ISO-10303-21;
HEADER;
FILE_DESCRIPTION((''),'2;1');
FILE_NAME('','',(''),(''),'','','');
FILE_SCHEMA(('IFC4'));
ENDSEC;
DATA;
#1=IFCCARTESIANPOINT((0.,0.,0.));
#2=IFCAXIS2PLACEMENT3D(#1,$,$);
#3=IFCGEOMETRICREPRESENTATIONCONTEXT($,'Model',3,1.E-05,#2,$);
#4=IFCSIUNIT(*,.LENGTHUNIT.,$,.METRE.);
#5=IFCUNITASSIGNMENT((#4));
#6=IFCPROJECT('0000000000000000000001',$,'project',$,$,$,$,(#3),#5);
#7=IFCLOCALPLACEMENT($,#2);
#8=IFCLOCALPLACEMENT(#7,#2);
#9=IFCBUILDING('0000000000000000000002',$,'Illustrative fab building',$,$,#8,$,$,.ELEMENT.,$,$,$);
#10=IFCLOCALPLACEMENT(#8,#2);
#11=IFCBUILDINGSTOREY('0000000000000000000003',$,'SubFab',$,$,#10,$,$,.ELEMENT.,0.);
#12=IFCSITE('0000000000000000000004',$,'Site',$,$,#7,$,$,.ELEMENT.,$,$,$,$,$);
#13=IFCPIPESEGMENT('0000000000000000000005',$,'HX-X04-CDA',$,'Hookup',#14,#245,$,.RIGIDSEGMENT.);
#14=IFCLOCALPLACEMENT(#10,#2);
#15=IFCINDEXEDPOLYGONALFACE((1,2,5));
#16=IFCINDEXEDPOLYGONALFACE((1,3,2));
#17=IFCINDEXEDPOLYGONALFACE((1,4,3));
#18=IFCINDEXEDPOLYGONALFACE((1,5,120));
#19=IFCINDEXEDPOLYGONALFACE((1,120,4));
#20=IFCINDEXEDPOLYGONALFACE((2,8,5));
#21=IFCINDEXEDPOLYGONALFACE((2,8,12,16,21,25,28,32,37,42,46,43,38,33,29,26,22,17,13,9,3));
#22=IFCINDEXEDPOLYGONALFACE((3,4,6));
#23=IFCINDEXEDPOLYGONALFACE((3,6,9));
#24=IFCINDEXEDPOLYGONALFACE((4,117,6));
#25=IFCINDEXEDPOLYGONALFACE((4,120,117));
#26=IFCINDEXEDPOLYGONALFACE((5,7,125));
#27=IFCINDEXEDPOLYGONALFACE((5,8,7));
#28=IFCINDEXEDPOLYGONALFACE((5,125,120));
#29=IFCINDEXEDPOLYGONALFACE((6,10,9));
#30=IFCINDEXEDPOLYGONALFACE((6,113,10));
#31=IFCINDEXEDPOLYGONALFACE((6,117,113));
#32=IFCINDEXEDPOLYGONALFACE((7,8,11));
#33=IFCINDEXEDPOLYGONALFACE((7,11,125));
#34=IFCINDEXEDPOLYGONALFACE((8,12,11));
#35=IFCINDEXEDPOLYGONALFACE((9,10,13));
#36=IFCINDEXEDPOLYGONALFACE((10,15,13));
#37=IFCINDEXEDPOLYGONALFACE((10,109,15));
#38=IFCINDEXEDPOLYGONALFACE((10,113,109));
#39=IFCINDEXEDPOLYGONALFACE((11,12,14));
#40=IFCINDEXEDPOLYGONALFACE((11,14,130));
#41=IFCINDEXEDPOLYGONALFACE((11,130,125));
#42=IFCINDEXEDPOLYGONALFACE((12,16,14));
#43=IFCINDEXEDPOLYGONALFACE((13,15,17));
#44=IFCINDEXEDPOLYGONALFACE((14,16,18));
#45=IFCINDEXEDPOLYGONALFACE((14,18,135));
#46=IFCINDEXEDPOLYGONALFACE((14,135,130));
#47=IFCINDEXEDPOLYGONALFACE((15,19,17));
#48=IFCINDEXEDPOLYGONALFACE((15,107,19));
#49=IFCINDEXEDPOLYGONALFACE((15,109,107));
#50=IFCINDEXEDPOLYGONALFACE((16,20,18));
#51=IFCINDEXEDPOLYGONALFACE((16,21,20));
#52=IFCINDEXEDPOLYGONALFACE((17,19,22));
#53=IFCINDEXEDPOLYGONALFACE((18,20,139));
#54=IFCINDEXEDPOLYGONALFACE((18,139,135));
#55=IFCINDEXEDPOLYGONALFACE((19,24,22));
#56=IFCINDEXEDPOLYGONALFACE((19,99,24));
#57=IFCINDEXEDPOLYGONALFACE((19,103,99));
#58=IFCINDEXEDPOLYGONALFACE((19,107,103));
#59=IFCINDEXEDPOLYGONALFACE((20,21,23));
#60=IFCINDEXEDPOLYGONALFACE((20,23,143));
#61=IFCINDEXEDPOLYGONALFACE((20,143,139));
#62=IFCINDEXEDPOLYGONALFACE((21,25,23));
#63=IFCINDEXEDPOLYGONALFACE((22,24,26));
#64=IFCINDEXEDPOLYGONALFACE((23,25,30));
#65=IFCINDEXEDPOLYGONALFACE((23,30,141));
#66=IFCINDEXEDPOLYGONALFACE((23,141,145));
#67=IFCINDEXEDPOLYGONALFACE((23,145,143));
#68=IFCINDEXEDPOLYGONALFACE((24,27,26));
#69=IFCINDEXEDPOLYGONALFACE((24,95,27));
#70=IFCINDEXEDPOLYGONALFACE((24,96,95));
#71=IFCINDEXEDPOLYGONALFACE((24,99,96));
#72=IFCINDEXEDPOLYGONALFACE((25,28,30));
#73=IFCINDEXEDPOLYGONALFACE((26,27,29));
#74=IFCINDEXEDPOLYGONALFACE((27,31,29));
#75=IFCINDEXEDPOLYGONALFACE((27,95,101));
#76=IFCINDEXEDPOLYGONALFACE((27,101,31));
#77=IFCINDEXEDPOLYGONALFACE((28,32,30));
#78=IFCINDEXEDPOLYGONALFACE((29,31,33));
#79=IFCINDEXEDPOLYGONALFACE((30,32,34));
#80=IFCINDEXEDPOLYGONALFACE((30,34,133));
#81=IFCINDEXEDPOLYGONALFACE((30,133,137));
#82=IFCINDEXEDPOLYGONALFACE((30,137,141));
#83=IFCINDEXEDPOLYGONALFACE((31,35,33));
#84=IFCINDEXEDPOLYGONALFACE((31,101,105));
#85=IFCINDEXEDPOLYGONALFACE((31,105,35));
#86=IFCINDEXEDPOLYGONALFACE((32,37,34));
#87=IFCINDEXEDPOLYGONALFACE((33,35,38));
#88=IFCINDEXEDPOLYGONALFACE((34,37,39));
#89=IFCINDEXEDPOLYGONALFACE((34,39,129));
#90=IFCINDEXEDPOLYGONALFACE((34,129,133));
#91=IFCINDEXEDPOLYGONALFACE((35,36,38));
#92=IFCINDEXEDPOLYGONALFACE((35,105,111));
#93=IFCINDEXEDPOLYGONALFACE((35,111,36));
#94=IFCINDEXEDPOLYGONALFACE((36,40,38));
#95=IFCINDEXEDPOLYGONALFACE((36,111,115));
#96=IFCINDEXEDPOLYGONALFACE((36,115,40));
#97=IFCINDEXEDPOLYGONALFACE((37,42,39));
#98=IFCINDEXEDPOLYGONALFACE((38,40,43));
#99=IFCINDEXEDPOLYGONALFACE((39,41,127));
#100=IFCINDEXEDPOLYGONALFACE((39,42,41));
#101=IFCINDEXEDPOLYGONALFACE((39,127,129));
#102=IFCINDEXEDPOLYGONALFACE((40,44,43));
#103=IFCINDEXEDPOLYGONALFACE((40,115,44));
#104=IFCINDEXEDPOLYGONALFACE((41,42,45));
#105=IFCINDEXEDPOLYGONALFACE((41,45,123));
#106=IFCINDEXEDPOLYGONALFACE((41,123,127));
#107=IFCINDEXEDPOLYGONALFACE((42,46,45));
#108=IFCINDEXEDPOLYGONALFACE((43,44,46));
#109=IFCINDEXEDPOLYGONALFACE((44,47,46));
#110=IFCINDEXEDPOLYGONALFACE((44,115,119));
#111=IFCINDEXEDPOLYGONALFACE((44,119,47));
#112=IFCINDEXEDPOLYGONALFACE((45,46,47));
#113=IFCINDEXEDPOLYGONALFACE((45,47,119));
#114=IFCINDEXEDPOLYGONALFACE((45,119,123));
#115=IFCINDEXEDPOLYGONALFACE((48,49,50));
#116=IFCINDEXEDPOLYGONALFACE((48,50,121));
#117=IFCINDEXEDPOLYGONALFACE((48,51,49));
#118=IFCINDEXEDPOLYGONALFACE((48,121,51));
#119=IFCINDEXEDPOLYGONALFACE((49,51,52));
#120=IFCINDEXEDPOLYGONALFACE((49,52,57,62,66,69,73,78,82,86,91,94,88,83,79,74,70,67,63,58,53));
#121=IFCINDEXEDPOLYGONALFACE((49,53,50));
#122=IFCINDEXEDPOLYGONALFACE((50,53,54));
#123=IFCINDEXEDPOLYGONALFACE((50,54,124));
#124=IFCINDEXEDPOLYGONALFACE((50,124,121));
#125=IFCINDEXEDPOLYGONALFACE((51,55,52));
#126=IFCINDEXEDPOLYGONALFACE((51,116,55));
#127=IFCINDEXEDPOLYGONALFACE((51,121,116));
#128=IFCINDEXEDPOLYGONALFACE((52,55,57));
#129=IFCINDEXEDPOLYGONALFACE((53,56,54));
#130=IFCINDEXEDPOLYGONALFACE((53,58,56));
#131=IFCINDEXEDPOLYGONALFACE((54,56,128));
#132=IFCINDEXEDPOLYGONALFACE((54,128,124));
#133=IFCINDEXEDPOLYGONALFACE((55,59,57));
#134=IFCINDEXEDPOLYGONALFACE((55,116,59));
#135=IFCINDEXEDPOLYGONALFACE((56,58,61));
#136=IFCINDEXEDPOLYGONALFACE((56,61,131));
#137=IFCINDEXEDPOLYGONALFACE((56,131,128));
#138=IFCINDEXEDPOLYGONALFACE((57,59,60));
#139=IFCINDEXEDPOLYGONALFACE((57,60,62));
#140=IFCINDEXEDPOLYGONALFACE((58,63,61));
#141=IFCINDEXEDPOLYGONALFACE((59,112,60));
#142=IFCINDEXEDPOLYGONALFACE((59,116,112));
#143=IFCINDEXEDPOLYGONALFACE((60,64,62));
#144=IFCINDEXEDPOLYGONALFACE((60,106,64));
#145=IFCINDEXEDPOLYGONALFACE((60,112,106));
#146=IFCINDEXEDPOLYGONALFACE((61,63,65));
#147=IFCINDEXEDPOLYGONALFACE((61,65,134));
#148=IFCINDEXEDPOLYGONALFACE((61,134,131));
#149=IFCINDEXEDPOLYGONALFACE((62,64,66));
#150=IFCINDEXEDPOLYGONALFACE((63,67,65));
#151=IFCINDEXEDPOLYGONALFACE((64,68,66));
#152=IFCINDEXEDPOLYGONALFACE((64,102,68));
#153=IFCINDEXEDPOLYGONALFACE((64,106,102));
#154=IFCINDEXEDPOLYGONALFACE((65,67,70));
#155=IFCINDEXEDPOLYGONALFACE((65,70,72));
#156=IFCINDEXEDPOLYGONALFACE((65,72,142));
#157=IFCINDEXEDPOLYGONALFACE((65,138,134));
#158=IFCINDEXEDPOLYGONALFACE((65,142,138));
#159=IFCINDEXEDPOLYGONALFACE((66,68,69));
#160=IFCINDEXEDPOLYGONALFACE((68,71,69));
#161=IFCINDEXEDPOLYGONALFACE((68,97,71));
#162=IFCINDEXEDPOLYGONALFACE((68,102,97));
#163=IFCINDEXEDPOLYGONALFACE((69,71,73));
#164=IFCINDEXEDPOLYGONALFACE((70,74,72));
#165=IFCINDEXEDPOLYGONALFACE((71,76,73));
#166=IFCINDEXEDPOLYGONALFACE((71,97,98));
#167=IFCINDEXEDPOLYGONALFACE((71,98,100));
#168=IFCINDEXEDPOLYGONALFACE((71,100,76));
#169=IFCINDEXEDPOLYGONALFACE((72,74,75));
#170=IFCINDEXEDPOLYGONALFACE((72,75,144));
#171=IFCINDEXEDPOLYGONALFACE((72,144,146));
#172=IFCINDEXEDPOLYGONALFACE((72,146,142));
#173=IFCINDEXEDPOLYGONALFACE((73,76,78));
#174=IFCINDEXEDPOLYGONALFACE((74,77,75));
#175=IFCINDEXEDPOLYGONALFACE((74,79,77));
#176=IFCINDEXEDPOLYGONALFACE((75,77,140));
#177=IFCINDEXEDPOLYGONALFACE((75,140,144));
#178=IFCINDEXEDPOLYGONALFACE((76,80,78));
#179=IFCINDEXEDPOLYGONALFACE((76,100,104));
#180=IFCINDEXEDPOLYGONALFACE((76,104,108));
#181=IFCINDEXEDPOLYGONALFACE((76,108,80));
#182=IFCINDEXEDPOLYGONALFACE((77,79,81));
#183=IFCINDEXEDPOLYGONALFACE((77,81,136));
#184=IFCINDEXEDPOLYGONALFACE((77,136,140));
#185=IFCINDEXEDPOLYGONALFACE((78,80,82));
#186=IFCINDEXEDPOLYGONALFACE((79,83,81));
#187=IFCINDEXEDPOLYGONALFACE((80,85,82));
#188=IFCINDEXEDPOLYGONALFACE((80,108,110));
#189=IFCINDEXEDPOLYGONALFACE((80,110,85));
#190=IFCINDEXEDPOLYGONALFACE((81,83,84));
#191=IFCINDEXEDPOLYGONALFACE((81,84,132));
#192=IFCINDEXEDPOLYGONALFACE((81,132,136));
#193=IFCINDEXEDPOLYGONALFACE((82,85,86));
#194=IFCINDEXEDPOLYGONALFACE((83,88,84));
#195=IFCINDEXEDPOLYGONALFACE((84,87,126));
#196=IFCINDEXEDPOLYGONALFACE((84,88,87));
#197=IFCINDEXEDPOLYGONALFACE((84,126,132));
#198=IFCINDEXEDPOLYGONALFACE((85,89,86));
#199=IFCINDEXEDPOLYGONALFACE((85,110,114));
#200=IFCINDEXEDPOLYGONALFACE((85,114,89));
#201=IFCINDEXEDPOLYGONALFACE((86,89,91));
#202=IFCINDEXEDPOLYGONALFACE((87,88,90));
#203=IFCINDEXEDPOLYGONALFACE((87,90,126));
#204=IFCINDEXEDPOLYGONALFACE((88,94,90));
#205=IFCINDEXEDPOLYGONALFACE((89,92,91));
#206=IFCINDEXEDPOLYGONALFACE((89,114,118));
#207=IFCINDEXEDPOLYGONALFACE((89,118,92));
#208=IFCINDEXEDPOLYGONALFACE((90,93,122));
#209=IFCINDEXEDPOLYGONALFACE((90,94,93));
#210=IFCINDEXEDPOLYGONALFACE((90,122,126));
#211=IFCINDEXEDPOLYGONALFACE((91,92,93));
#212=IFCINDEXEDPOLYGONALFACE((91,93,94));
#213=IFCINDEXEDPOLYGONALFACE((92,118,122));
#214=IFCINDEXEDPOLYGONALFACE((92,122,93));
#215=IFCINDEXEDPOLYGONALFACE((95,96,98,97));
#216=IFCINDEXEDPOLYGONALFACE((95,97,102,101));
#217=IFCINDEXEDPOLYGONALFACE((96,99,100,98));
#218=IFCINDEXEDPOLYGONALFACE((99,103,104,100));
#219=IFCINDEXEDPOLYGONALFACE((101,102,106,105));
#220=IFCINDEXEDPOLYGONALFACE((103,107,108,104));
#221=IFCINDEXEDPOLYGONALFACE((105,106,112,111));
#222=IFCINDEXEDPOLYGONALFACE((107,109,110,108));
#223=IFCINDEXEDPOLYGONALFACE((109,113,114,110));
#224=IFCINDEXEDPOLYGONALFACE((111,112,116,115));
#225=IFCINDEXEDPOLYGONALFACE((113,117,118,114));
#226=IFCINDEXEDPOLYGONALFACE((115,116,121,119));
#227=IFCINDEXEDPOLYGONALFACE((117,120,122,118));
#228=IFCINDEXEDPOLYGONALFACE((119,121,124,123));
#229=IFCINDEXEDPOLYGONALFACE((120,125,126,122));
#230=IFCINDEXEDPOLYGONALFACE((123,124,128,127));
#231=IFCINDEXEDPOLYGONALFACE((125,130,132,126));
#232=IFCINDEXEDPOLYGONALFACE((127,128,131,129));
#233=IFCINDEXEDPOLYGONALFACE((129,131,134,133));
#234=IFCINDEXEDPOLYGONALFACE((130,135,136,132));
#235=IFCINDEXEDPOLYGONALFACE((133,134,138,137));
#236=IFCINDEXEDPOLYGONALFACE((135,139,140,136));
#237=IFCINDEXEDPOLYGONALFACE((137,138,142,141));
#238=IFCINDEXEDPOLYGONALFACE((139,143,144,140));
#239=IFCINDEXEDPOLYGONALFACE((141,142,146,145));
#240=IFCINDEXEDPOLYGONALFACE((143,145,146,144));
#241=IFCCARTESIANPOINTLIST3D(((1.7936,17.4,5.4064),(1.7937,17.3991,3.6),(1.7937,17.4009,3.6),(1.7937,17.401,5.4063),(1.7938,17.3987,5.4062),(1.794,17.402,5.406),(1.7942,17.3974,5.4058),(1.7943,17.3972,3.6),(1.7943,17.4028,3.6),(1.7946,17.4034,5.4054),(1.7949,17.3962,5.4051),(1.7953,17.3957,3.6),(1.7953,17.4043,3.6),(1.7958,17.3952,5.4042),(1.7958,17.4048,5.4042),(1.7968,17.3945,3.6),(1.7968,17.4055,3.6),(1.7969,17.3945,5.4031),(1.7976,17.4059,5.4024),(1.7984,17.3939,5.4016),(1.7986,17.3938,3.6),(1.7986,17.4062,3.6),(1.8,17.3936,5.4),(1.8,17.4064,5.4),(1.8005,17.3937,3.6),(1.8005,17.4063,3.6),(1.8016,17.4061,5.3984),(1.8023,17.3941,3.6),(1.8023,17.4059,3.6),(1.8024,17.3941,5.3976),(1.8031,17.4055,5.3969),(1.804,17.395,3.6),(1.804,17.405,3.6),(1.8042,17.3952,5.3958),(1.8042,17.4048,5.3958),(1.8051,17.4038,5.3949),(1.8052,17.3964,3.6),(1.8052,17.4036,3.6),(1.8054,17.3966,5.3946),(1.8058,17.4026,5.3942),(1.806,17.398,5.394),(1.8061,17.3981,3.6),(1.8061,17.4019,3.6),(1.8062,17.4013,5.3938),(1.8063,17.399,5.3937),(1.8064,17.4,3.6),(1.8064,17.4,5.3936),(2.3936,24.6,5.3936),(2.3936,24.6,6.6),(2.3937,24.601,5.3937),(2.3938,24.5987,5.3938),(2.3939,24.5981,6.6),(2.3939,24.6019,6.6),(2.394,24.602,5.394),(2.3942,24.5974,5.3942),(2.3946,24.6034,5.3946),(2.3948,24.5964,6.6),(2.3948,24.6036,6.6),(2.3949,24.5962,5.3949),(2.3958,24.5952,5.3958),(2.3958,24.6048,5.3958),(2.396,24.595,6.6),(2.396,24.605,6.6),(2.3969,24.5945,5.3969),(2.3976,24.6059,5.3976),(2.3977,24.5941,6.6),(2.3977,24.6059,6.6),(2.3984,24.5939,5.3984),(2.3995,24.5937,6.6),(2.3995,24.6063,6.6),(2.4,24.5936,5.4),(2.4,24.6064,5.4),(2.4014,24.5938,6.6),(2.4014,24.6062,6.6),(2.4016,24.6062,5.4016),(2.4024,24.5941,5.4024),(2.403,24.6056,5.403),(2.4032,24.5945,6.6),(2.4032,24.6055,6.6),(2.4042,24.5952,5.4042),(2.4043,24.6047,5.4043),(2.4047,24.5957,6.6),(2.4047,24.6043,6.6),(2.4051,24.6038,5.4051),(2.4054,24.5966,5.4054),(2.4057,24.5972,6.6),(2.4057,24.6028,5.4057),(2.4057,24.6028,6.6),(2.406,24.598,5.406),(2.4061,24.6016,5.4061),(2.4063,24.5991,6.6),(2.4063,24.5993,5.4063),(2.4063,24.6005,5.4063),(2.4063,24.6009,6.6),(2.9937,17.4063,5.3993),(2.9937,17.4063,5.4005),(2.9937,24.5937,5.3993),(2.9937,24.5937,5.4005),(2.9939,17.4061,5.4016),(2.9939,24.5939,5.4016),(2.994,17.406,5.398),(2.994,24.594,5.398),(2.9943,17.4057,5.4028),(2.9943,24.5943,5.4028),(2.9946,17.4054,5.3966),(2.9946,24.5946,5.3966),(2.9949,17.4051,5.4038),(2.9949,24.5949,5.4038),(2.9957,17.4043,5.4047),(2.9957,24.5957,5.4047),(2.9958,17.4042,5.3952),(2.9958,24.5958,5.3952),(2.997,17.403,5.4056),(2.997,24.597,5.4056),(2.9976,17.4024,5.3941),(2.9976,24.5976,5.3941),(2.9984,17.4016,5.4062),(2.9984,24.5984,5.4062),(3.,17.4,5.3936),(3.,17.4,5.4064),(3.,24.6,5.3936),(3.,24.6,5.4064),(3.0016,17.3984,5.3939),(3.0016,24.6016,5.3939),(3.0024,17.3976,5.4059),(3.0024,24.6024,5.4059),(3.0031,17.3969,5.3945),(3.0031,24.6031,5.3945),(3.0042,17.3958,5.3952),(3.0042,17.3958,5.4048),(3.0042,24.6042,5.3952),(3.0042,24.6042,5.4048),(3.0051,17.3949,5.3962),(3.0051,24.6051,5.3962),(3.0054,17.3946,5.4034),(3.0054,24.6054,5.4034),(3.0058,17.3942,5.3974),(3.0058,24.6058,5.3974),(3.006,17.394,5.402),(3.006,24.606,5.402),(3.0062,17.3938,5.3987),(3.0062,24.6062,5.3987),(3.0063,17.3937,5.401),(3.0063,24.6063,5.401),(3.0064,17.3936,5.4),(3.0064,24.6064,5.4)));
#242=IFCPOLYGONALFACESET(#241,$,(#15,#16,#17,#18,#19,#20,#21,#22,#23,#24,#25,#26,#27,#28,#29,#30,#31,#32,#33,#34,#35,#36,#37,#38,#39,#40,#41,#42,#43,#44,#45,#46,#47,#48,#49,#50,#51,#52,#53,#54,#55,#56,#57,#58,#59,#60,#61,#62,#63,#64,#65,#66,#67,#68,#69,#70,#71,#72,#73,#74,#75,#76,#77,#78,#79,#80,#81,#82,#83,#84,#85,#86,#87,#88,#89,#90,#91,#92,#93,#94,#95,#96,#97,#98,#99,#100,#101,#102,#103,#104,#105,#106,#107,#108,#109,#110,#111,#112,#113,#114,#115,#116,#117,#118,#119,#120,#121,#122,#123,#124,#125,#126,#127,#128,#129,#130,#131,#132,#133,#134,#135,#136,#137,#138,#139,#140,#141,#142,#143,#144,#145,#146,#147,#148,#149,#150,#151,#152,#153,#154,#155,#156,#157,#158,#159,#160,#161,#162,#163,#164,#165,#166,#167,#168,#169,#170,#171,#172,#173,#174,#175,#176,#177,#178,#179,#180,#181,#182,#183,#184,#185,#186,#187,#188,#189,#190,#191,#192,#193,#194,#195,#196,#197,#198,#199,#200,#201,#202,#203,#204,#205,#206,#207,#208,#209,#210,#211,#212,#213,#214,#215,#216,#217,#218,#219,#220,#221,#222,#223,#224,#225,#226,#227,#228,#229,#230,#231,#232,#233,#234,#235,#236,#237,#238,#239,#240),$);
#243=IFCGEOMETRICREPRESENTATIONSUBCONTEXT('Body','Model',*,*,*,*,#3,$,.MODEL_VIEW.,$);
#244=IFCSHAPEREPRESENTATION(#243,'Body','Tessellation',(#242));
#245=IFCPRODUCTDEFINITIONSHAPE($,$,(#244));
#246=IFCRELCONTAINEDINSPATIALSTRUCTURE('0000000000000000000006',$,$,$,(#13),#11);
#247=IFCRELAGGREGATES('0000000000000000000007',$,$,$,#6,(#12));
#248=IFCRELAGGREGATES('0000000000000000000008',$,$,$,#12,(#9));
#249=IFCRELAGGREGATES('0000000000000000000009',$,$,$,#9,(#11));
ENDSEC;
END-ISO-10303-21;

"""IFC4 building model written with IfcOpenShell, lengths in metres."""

from ifc_helpers import new_model, entity, si_unit, origin, place, context, subcontext, project, spatial, element, save


model = new_model("IFC4")

# Units and contexts
model_context = context("Model", 3, precision=1e-05, world=origin())
body_context = subcontext(model_context, "Body", "Model", "MODEL_VIEW")
ifc_project = project(units=[si_unit("LENGTHUNIT", "METRE")], contexts=[model_context])

# Site, building, storey
site_placement = place(None, origin())
site = spatial("IfcSite", under=ifc_project, at=site_placement, Name="Site", CompositionType="ELEMENT")
building_placement = place(site_placement, origin())
building = spatial("IfcBuilding", under=site, at=building_placement, Name="Illustrative fab building", CompositionType="ELEMENT")
storey_placement = place(building_placement, origin())
storey = spatial("IfcBuildingStorey", under=building, at=storey_placement, Name="SubFab", CompositionType="ELEMENT", Elevation=0.0)

# Pipe segment
pipe_segment_1_placement = place(storey_placement, origin())
element("IfcPipeSegment", 1, at=pipe_segment_1_placement, inside=storey, Name="HX-X04-CDA", ObjectType="Hookup", PredefinedType="RIGIDSEGMENT", context=body_context, shape_type="AdvancedSweptSolid", body=[
    entity("IfcSweptDiskSolid", entity("IfcPolyline", [entity("IfcCartesianPoint", [1.8, 17.4, 3.6]), entity("IfcCartesianPoint", [1.8, 17.4, 5.4]), entity("IfcCartesianPoint", [3.0, 17.4, 5.4]), entity("IfcCartesianPoint", [3.0, 24.6, 5.4]), entity("IfcCartesianPoint", [2.4, 24.6, 5.4]), entity("IfcCartesianPoint", [2.4, 24.6, 6.6])]), 0.0063),
])

save(model, "model.ifc")
